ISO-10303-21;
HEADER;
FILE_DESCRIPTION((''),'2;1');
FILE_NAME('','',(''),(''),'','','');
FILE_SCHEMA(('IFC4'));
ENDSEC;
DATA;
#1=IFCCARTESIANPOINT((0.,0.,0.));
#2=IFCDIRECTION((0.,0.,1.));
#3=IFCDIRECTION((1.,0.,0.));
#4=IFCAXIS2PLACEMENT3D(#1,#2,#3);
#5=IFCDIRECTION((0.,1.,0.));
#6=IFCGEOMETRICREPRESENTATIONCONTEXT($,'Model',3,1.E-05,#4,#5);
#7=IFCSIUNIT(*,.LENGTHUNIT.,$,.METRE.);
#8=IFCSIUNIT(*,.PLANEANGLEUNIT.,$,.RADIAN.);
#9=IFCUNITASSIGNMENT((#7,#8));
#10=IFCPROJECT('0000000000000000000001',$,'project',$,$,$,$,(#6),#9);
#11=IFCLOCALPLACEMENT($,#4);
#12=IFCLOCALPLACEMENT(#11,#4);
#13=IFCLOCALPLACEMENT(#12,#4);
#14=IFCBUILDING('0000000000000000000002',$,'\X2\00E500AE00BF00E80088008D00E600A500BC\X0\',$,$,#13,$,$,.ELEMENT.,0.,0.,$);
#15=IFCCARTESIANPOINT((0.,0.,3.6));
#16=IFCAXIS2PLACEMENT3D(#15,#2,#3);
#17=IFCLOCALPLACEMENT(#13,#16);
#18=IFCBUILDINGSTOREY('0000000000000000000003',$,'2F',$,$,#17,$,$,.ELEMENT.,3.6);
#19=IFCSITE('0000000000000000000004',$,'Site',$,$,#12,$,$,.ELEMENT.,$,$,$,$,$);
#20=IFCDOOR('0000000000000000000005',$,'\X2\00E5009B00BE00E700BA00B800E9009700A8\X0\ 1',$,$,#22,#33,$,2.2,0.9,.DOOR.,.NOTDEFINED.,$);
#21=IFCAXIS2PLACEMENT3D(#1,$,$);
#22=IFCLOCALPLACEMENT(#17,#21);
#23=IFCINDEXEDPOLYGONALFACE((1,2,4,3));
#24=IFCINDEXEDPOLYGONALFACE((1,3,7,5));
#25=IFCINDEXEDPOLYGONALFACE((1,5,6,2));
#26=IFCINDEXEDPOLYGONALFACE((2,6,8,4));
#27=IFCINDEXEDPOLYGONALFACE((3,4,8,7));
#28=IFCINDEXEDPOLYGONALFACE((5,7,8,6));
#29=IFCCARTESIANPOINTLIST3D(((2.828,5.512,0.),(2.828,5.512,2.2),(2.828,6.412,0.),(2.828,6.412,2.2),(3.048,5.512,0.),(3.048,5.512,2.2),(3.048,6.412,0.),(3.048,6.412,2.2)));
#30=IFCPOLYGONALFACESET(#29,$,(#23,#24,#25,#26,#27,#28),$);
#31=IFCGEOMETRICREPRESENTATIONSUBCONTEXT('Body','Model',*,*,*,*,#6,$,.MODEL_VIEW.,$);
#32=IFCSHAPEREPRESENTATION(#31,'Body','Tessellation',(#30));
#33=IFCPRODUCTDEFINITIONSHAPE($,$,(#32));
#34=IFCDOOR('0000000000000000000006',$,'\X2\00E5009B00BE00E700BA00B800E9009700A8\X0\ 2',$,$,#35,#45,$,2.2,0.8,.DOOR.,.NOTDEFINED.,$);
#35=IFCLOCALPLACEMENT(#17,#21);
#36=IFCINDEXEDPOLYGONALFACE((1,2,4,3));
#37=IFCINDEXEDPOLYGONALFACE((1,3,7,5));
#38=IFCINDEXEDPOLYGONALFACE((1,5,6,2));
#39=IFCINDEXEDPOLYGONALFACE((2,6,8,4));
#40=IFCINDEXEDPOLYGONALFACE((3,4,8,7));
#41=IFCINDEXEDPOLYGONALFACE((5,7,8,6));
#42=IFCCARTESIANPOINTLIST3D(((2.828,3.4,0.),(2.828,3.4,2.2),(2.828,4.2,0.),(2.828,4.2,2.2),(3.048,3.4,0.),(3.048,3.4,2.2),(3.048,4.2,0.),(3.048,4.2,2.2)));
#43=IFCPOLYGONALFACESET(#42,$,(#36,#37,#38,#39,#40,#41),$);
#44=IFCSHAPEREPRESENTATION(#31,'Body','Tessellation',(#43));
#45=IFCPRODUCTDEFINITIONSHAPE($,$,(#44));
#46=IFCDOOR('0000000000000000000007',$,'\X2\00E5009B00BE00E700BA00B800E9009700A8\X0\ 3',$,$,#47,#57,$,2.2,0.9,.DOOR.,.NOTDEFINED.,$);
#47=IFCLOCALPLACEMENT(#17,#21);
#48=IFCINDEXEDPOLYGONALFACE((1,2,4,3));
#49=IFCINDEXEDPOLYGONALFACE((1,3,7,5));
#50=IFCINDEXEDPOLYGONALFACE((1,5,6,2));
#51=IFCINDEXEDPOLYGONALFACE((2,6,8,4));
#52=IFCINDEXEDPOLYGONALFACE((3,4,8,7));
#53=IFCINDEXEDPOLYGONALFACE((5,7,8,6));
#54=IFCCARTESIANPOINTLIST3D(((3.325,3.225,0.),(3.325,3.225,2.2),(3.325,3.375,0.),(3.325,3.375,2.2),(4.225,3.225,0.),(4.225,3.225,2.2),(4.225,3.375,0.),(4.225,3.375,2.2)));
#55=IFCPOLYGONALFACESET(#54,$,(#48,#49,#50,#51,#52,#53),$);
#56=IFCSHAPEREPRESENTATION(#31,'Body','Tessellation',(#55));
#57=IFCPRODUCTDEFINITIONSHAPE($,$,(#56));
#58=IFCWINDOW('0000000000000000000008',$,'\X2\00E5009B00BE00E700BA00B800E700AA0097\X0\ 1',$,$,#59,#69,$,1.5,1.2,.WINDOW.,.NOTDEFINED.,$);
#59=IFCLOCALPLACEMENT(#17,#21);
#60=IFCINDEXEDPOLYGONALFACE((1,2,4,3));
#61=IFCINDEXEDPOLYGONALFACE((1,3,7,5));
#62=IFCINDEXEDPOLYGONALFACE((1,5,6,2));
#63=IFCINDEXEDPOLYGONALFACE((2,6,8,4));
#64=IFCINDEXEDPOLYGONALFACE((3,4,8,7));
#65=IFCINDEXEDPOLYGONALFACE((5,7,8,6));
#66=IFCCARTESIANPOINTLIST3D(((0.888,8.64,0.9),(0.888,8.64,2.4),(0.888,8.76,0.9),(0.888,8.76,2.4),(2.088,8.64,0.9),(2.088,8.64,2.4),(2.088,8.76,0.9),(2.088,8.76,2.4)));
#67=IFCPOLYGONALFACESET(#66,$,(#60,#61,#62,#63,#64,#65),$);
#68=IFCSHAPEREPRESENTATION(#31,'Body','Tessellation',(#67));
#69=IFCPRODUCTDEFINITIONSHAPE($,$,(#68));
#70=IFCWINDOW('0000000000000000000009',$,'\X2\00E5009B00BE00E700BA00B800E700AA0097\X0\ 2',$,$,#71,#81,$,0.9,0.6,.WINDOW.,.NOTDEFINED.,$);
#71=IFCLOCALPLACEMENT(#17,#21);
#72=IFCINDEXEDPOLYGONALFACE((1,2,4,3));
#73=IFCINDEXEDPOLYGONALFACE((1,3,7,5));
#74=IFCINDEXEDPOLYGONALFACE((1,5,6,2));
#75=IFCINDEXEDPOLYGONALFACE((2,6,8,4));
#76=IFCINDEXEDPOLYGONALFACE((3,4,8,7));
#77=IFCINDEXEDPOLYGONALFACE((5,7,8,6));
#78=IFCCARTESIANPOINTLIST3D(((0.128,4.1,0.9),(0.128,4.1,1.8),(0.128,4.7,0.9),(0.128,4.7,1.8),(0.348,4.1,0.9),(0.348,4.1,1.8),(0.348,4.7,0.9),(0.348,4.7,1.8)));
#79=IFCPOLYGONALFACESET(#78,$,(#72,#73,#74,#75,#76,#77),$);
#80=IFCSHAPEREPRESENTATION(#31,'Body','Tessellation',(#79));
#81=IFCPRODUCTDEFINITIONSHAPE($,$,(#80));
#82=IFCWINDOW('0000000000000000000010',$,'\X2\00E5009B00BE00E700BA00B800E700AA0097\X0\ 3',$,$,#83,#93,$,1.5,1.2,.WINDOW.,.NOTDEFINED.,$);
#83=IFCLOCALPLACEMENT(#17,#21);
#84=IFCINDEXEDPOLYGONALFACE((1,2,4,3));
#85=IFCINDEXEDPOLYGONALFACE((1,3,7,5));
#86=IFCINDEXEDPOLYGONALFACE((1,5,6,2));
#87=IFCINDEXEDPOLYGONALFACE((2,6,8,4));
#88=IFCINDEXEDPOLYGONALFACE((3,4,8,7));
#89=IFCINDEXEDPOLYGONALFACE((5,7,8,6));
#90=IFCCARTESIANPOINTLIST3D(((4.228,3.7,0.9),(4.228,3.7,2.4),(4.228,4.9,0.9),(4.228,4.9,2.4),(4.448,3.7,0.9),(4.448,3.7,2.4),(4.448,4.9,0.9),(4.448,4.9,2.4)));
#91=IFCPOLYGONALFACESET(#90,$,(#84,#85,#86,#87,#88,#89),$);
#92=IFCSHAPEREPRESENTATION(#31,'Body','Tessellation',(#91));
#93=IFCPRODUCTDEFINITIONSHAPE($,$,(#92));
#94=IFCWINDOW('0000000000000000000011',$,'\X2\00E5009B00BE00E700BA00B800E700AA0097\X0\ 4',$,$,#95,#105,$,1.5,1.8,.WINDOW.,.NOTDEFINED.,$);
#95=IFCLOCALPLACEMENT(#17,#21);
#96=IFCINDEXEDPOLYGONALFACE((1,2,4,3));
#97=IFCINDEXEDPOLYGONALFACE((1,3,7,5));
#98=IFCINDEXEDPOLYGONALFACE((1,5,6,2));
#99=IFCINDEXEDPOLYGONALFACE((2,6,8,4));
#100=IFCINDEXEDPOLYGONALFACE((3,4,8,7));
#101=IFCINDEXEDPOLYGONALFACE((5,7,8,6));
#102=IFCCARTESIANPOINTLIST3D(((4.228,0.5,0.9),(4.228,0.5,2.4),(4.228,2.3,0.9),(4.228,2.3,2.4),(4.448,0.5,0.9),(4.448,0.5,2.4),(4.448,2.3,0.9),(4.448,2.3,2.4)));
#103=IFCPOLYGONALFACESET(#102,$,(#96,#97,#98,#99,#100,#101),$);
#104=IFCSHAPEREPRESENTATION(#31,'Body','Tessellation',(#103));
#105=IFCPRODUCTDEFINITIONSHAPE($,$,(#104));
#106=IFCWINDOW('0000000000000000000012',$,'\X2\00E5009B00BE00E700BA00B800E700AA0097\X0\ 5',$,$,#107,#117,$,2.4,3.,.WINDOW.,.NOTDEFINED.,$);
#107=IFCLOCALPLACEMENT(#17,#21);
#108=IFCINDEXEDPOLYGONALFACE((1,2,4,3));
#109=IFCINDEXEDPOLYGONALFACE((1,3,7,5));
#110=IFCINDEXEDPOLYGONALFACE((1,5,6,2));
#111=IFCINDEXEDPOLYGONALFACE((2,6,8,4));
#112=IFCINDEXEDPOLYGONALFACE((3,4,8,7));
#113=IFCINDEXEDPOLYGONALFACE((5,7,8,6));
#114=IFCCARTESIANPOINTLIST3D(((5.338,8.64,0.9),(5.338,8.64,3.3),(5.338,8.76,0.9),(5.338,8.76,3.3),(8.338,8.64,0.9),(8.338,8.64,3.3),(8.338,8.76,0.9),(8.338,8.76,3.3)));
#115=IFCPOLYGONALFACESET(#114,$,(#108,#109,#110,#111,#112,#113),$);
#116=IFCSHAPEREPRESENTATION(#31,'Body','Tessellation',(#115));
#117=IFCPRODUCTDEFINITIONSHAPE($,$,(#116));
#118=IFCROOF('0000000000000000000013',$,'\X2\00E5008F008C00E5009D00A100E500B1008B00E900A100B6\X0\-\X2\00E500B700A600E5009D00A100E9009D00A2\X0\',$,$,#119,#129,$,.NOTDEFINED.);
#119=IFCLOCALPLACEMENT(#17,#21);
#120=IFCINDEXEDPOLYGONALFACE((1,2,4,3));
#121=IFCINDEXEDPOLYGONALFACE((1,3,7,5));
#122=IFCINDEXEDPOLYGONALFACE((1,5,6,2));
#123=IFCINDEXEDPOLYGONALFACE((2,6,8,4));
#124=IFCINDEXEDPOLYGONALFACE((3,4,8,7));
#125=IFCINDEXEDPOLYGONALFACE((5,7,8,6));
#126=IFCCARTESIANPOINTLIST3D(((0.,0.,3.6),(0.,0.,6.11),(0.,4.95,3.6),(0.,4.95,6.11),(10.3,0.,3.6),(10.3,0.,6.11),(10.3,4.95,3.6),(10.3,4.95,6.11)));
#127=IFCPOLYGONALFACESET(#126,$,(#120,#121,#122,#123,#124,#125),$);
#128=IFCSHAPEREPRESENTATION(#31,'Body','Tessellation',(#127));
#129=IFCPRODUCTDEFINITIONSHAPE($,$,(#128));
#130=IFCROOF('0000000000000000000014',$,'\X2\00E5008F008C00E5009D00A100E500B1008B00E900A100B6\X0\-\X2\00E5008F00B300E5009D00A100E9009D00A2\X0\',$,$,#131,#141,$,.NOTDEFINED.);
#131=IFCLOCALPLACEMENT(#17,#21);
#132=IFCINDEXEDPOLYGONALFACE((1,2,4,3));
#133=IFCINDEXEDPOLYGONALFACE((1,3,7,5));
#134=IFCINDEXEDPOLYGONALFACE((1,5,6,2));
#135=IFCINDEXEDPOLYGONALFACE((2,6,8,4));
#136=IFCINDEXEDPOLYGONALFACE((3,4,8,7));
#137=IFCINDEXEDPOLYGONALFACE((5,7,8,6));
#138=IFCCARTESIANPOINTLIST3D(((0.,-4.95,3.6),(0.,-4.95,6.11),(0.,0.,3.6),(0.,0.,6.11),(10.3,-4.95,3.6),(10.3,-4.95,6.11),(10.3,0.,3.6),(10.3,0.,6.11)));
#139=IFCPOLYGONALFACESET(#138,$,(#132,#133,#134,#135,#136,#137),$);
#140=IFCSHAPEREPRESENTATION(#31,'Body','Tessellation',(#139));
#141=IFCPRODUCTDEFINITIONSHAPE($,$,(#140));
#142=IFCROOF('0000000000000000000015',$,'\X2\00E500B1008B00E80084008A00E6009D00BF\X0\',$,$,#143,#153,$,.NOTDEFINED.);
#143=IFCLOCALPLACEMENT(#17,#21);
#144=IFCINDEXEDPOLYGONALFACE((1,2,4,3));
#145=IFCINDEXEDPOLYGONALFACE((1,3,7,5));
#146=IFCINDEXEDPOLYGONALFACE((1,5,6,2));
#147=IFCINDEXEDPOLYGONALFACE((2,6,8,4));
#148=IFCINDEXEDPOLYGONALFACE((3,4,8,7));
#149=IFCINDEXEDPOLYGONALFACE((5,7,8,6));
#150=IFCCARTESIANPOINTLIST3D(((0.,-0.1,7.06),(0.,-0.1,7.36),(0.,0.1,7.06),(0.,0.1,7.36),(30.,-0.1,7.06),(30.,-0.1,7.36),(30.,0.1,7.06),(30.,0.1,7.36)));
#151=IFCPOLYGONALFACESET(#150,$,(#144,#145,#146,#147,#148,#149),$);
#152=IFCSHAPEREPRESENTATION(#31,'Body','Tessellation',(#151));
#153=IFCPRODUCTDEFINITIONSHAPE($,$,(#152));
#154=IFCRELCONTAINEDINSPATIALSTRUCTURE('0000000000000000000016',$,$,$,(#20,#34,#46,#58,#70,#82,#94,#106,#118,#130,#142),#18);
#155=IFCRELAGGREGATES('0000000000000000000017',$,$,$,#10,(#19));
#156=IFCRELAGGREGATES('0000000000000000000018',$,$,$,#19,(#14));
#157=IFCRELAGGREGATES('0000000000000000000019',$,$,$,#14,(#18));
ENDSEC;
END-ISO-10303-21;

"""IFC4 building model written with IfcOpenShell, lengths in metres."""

from ifc_helpers import new_model, si_unit, direction, frame, frame_2d, origin_with_axes, place, context, subcontext, project, spatial, rectangle, extrude, element, save


model = new_model("IFC4")

# Units and contexts
model_context = context("Model", 3, precision=1e-05, world=origin_with_axes(), true_north=direction((0.0, 1.0, 0.0)))
body_context = subcontext(model_context, "Body", "Model", "MODEL_VIEW")
ifc_project = project(units=[si_unit("LENGTHUNIT", "METRE"), si_unit("PLANEANGLEUNIT", "RADIAN")], contexts=[model_context])

# Site, building, storey
placement = place(None, origin_with_axes())
site_placement = place(placement, origin_with_axes())
site = spatial("IfcSite", under=ifc_project, at=site_placement, Name="Site", CompositionType="ELEMENT")
building_placement = place(site_placement, origin_with_axes())
building = spatial("IfcBuilding", under=site, at=building_placement, Name="å®¿è\u0088\u008dæ¥¼", CompositionType="ELEMENT", ElevationOfRefHeight=0.0, ElevationOfTerrain=0.0)
storey_placement = place(building_placement, frame((0.0, 0.0, 3.6), z_axis=(0.0, 0.0, 1.0), x_axis=(1.0, 0.0, 0.0)))
storey = spatial("IfcBuildingStorey", under=building, at=storey_placement, Name="2F", CompositionType="ELEMENT", Elevation=3.6)

# Doors
door_1_placement = place(storey_placement, frame((2.938, 5.962, 0.0), z_axis=(0.0, 0.0, 1.0), x_axis=(0.0, 1.0, 0.0)))
element("IfcDoor", 1, at=door_1_placement, inside=storey, Name="å\u009b¾çº¸é\u0097¨ 1", OperationType="NOTDEFINED", OverallHeight=2.2, OverallWidth=0.9, PredefinedType="DOOR", context=body_context, shape_type="SweptSolid", body=[
    extrude(rectangle(XDim=0.9, YDim=0.22, at=frame_2d((0.0, 0.0), x_axis=(1.0, 0.0, 0.0))), frame((0.0, 0.0, 0.0), z_axis=(0.0, 0.0, 1.0)), (0.0, 0.0, 1.0), 2.2),
])
door_2_placement = place(storey_placement, frame((2.938, 3.8, 0.0), z_axis=(0.0, 0.0, 1.0), x_axis=(0.0, 1.0, 0.0)))
element("IfcDoor", 2, at=door_2_placement, inside=storey, Name="å\u009b¾çº¸é\u0097¨ 2", OperationType="NOTDEFINED", OverallHeight=2.2, OverallWidth=0.8, PredefinedType="DOOR", context=body_context, shape_type="SweptSolid", body=[
    extrude(rectangle(XDim=0.8, YDim=0.22, at=frame_2d((0.0, 0.0), x_axis=(1.0, 0.0, 0.0))), frame((0.0, 0.0, 0.0), z_axis=(0.0, 0.0, 1.0)), (0.0, 0.0, 1.0), 2.2),
])
door_3_placement = place(storey_placement, frame((3.775, 3.3, 0.0), z_axis=(0.0, 0.0, 1.0), x_axis=(1.0, 0.0, 0.0)))
element("IfcDoor", 3, at=door_3_placement, inside=storey, Name="å\u009b¾çº¸é\u0097¨ 3", OperationType="NOTDEFINED", OverallHeight=2.2, OverallWidth=0.9, PredefinedType="DOOR", context=body_context, shape_type="SweptSolid", body=[
    extrude(rectangle(XDim=0.9, YDim=0.15, at=frame_2d((0.0, 0.0), x_axis=(1.0, 0.0, 0.0))), frame((0.0, 0.0, 0.0), z_axis=(0.0, 0.0, 1.0)), (0.0, 0.0, 1.0), 2.2),
])

# Windows
window_1_placement = place(storey_placement, frame((1.488, 8.7, 0.9), z_axis=(0.0, 0.0, 1.0), x_axis=(1.0, 0.0, 0.0)))
element("IfcWindow", 4, at=window_1_placement, inside=storey, Name="å\u009b¾çº¸çª\u0097 1", OverallHeight=1.5, OverallWidth=1.2, PartitioningType="NOTDEFINED", PredefinedType="WINDOW", context=body_context, shape_type="SweptSolid", body=[
    extrude(rectangle(XDim=1.2, YDim=0.12, at=frame_2d((0.0, 0.0), x_axis=(1.0, 0.0, 0.0))), frame((0.0, 0.0, 0.0), z_axis=(0.0, 0.0, 1.0)), (0.0, 0.0, 1.0), 1.5),
])
window_2_placement = place(storey_placement, frame((0.238, 4.4, 0.9), z_axis=(0.0, 0.0, 1.0), x_axis=(0.0, 1.0, 0.0)))
element("IfcWindow", 5, at=window_2_placement, inside=storey, Name="å\u009b¾çº¸çª\u0097 2", OverallHeight=0.9, OverallWidth=0.6, PartitioningType="NOTDEFINED", PredefinedType="WINDOW", context=body_context, shape_type="SweptSolid", body=[
    extrude(rectangle(XDim=0.6, YDim=0.22, at=frame_2d((0.0, 0.0), x_axis=(1.0, 0.0, 0.0))), frame((0.0, 0.0, 0.0), z_axis=(0.0, 0.0, 1.0)), (0.0, 0.0, 1.0), 0.9),
])
window_3_placement = place(storey_placement, frame((4.338, 4.3, 0.9), z_axis=(0.0, 0.0, 1.0), x_axis=(0.0, 1.0, 0.0)))
element("IfcWindow", 6, at=window_3_placement, inside=storey, Name="å\u009b¾çº¸çª\u0097 3", OverallHeight=1.5, OverallWidth=1.2, PartitioningType="NOTDEFINED", PredefinedType="WINDOW", context=body_context, shape_type="SweptSolid", body=[
    extrude(rectangle(XDim=1.2, YDim=0.22, at=frame_2d((0.0, 0.0), x_axis=(1.0, 0.0, 0.0))), frame((0.0, 0.0, 0.0), z_axis=(0.0, 0.0, 1.0)), (0.0, 0.0, 1.0), 1.5),
])
window_4_placement = place(storey_placement, frame((4.338, 1.4, 0.9), z_axis=(0.0, 0.0, 1.0), x_axis=(0.0, 1.0, 0.0)))
element("IfcWindow", 7, at=window_4_placement, inside=storey, Name="å\u009b¾çº¸çª\u0097 4", OverallHeight=1.5, OverallWidth=1.8, PartitioningType="NOTDEFINED", PredefinedType="WINDOW", context=body_context, shape_type="SweptSolid", body=[
    extrude(rectangle(XDim=1.8, YDim=0.22, at=frame_2d((0.0, 0.0), x_axis=(1.0, 0.0, 0.0))), frame((0.0, 0.0, 0.0), z_axis=(0.0, 0.0, 1.0)), (0.0, 0.0, 1.0), 1.5),
])
window_5_placement = place(storey_placement, frame((6.838, 8.7, 0.9), z_axis=(0.0, 0.0, 1.0), x_axis=(-1.0, 0.0, 0.0)))
element("IfcWindow", 8, at=window_5_placement, inside=storey, Name="å\u009b¾çº¸çª\u0097 5", OverallHeight=2.4, OverallWidth=3.0, PartitioningType="NOTDEFINED", PredefinedType="WINDOW", context=body_context, shape_type="SweptSolid", body=[
    extrude(rectangle(XDim=3.0, YDim=0.12, at=frame_2d((0.0, 0.0), x_axis=(1.0, 0.0, 0.0))), frame((0.0, 0.0, 0.0), z_axis=(0.0, 0.0, 1.0)), (0.0, 0.0, 1.0), 2.4),
])

# Roofs
for number, where, z_axis, x_axis, name in (
    (9, (5.15, 2.475, 3.6), (0.0, 0.0, 1.0), (1.0, 0.0, 0.0), "å\u008f\u008cå\u009d¡å±\u008bé¡¶-å·¦å\u009d¡é\u009d¢"),
    (10, (5.15, -2.475, 3.6), (0.0, 0.0, 1.0), (1.0, 0.0, 0.0), "å\u008f\u008cå\u009d¡å±\u008bé¡¶-å\u008f³å\u009d¡é\u009d¢"),
):
    element("IfcRoof", number, at=place(storey_placement, frame(where, z_axis=z_axis, x_axis=x_axis)), inside=storey, Name=name, PredefinedType="NOTDEFINED", context=body_context, shape_type="SweptSolid", body=[
        extrude(rectangle(XDim=10.3, YDim=4.95, at=frame_2d((0.0, 0.0), x_axis=(1.0, 0.0, 0.0))), frame((0.0, 0.0, 0.0), z_axis=(0.0, 0.0, 1.0)), (0.0, 0.0, 1.0), 2.51),
    ])
roof_placement = place(storey_placement, frame((15.0, 0.0, 7.06), z_axis=(0.0, 0.0, 1.0), x_axis=(1.0, 0.0, 0.0)))
element("IfcRoof", 11, at=roof_placement, inside=storey, Name="å±\u008bè\u0084\u008aæ\u009d¿", PredefinedType="NOTDEFINED", context=body_context, shape_type="SweptSolid", body=[
    extrude(rectangle(XDim=30.0, YDim=0.2, at=frame_2d((0.0, 0.0), x_axis=(1.0, 0.0, 0.0))), frame((0.0, 0.0, 0.0), z_axis=(0.0, 0.0, 1.0)), (0.0, 0.0, 1.0), 0.3),
])

save(model, "model.ifc")
